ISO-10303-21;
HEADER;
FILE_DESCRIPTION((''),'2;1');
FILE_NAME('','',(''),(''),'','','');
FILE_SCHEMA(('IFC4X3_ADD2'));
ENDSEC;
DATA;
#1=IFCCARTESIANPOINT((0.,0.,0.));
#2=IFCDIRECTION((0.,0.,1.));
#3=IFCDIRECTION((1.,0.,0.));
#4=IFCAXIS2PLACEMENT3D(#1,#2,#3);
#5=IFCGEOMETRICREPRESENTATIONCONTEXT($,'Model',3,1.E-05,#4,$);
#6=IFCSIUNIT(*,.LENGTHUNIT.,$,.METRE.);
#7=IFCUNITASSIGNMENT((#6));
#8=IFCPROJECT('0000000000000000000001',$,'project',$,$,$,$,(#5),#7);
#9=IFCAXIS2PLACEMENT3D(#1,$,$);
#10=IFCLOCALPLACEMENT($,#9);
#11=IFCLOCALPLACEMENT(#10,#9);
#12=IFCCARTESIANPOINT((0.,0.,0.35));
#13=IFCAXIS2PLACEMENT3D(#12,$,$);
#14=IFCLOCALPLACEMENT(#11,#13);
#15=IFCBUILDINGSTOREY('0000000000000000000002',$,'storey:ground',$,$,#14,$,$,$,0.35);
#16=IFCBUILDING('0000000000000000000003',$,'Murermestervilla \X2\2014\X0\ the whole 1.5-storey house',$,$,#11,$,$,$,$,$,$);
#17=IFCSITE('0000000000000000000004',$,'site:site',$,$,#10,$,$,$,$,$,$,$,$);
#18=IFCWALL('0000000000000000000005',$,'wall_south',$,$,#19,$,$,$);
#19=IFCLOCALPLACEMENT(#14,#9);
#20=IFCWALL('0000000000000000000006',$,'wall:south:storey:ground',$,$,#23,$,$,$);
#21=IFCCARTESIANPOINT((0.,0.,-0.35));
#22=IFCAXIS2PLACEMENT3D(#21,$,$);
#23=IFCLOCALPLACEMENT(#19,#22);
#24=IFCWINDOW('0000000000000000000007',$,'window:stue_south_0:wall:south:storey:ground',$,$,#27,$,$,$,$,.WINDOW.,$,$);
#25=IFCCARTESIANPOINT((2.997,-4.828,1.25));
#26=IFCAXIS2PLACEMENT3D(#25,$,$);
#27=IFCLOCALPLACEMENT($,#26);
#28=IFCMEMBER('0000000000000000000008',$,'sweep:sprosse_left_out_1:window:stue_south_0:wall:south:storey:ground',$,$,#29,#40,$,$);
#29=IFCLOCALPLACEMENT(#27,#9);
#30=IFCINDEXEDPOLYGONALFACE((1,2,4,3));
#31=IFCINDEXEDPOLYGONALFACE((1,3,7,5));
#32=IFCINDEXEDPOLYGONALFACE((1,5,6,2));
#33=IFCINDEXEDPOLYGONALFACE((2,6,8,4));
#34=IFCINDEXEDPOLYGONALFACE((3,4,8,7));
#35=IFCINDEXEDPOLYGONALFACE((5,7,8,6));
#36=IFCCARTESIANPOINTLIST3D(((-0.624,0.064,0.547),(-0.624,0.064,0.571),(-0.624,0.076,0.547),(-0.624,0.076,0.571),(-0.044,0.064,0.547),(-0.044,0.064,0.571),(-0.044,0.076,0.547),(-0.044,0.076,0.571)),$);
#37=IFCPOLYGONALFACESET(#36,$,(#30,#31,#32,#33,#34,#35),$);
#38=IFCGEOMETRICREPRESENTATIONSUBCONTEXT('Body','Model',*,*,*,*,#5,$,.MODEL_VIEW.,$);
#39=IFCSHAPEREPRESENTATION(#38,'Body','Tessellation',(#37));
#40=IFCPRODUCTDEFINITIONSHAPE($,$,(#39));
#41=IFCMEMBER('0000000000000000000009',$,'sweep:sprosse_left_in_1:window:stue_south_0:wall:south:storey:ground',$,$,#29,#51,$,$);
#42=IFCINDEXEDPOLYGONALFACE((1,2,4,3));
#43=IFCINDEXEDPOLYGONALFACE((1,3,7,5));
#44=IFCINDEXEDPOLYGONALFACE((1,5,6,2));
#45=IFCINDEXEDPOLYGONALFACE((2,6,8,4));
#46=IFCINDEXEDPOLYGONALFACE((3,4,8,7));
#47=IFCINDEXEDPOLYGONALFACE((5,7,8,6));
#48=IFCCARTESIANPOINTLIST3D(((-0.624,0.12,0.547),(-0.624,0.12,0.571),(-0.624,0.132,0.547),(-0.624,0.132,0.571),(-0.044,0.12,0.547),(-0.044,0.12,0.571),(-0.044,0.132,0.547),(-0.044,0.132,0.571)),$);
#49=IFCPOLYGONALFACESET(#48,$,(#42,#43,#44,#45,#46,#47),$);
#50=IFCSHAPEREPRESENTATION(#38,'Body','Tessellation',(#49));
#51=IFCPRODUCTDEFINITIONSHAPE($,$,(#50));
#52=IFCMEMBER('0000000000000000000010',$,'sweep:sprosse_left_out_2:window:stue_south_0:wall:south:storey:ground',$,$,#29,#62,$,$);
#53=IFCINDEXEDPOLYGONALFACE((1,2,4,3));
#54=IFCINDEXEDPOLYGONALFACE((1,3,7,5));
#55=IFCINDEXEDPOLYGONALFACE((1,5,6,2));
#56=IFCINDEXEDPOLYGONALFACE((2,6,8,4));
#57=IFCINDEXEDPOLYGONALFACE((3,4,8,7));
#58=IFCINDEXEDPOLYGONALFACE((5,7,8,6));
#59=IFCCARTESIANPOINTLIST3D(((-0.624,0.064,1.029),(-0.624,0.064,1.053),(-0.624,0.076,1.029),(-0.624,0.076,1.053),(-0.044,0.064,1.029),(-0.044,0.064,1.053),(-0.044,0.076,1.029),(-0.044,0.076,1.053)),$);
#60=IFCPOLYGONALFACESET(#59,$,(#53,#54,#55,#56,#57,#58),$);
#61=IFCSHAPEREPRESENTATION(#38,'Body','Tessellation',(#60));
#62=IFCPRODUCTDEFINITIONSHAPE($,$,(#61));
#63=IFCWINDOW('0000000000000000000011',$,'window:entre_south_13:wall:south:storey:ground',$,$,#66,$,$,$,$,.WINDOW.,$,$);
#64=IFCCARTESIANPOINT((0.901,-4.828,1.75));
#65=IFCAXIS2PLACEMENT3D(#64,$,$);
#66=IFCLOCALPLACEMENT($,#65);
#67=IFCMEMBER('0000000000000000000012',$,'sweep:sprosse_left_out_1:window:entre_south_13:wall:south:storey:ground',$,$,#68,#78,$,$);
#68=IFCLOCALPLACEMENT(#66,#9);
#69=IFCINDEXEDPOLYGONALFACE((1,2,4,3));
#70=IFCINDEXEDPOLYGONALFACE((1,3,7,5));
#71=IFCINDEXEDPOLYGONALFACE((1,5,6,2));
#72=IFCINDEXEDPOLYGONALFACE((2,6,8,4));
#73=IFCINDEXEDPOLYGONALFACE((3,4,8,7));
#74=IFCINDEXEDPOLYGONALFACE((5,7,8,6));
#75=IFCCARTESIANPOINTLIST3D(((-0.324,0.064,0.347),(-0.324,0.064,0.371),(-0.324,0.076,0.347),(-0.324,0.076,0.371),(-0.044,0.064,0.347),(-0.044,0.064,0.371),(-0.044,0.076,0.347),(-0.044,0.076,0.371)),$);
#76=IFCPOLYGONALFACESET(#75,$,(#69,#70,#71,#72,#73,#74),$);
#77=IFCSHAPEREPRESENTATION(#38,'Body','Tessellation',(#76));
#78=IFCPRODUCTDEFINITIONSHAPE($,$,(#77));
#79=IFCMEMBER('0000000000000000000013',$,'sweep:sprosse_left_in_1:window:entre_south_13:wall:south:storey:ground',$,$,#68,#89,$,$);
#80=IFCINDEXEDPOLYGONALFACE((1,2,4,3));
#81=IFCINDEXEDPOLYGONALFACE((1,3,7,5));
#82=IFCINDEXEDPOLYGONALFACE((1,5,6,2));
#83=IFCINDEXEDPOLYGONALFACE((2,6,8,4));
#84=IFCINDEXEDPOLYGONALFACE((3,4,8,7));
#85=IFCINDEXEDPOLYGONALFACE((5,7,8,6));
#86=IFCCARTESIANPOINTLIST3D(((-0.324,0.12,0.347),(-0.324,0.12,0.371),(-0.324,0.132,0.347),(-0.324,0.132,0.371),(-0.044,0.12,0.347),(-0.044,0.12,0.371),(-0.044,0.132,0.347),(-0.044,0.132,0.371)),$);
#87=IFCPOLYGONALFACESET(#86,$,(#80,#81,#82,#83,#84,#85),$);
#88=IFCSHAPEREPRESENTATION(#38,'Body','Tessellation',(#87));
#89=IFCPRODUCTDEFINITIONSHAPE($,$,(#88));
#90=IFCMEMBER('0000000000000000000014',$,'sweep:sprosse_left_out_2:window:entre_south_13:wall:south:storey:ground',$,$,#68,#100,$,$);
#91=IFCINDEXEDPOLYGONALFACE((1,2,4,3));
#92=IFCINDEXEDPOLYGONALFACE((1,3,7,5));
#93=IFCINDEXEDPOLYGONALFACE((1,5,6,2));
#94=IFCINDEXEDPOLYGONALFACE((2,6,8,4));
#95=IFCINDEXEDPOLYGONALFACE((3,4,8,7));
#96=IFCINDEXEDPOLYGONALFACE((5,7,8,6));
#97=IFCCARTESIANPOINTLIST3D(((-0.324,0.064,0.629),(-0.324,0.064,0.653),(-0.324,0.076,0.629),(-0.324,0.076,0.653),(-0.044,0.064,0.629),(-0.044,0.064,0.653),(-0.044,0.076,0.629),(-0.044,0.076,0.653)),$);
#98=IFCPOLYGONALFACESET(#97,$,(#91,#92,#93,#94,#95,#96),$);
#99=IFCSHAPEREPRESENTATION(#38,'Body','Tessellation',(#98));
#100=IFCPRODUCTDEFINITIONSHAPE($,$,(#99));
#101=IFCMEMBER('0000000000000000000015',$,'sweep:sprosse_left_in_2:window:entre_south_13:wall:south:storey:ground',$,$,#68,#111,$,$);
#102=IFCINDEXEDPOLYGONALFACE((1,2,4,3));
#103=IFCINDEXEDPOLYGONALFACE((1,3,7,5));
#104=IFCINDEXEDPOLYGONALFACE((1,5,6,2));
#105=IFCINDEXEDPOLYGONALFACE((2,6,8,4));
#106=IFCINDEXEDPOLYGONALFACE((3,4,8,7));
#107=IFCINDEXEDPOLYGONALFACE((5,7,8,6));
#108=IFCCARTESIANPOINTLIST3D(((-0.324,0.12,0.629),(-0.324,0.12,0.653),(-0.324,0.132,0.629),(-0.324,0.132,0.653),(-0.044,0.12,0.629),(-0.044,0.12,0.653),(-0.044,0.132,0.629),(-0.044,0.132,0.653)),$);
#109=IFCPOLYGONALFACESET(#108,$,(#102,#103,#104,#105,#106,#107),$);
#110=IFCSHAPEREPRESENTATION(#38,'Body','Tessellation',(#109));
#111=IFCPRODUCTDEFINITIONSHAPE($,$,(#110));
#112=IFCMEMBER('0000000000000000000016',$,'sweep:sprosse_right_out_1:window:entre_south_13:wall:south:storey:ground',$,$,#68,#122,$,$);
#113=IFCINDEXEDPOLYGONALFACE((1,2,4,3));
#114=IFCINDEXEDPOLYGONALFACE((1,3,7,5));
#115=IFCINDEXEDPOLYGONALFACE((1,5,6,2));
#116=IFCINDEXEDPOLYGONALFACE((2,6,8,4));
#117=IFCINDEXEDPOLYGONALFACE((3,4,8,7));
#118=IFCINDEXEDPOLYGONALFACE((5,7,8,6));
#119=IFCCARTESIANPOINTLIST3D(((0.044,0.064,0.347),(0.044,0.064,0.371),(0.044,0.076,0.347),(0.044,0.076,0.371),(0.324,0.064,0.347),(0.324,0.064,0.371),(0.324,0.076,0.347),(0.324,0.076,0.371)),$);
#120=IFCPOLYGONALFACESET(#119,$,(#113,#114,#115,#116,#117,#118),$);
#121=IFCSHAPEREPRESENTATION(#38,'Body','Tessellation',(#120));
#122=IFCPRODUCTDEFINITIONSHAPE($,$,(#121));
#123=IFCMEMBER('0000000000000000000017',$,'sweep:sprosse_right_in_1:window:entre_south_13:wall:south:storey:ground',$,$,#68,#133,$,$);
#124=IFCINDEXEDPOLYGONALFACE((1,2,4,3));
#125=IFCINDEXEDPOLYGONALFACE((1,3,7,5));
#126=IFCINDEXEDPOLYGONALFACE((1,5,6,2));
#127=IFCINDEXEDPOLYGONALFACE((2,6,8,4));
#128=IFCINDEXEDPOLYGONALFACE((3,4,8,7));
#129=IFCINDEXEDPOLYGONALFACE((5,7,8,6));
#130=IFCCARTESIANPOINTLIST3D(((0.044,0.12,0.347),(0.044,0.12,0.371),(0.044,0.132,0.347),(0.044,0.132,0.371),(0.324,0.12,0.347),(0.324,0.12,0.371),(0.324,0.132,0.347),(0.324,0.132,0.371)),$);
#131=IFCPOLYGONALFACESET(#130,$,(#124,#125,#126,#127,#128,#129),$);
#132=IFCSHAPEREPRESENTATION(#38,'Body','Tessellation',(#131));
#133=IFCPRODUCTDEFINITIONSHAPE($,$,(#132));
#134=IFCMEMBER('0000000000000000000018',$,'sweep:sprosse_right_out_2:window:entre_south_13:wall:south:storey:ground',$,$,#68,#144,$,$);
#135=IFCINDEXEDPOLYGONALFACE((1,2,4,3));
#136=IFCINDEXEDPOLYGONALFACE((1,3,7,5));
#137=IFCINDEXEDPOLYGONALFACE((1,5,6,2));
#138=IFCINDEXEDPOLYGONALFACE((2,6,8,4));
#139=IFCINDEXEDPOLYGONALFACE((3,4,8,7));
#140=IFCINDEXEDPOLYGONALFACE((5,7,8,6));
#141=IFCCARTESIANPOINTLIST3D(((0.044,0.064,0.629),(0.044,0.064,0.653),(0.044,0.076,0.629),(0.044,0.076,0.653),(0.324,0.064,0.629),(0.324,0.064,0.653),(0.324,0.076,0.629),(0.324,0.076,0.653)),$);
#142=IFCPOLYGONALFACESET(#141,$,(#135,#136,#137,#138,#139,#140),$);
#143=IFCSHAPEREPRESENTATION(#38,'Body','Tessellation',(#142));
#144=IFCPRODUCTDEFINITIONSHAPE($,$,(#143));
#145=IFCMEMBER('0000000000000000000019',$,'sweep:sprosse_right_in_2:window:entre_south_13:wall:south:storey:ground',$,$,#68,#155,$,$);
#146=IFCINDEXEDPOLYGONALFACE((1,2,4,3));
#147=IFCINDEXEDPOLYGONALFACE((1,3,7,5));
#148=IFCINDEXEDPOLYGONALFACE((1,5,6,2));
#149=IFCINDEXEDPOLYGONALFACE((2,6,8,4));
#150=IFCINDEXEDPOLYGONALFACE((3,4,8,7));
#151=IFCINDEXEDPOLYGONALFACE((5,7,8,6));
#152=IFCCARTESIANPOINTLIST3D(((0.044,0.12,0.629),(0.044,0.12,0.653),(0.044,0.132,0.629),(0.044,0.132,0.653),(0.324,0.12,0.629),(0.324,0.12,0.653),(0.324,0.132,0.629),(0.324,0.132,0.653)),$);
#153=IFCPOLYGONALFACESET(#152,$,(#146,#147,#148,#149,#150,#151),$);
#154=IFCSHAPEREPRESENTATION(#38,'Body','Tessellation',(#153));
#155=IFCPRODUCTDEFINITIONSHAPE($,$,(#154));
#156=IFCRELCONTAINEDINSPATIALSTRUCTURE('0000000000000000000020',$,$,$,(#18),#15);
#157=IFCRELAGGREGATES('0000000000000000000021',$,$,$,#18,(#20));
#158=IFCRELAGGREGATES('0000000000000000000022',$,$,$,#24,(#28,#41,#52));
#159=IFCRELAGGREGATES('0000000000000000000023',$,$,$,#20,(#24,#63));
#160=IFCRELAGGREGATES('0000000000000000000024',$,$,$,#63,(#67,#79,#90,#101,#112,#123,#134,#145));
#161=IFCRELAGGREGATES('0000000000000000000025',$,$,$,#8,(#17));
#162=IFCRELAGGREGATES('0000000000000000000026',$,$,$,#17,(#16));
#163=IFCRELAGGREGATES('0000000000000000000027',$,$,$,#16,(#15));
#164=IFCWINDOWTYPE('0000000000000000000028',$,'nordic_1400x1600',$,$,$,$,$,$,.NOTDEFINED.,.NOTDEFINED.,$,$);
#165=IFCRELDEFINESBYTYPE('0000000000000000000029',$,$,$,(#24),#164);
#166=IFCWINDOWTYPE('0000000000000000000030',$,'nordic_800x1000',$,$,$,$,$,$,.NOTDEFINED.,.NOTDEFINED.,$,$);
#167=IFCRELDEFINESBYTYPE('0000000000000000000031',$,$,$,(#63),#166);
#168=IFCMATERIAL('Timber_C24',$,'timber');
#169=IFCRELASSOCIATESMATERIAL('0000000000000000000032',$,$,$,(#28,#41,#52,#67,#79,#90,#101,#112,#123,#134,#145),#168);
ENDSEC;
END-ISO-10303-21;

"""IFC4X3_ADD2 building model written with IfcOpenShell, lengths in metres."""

from ifc_helpers import new_model, si_unit, frame, origin, origin_with_axes, place, context, subcontext, project, spatial, polyline, outline, extrude, source, transform, mapped, material, type_object, element, aggregate, save


model = new_model("IFC4X3_ADD2")

# Units and contexts
model_context = context("Model", 3, precision=1e-05, world=origin_with_axes())
body_context = subcontext(model_context, "Body", "Model", "MODEL_VIEW")
ifc_project = project(units=[si_unit("LENGTHUNIT", "METRE")], contexts=[model_context])

# Site, building, storey
site_placement = place(None, origin())
site = spatial("IfcSite", under=ifc_project, at=site_placement, Name="site:site")
building_placement = place(site_placement, origin())
building = spatial("IfcBuilding", under=site, at=building_placement, Name="Murermestervilla — the whole 1.5-storey house")
storey_placement = place(building_placement, frame((0.0, 0.0, 0.35)))
storey = spatial("IfcBuildingStorey", under=building, at=storey_placement, Name="storey:ground", Elevation=0.35)

# Walls, windows, members
wall_1_placement = place(storey_placement, origin())
wall_1 = element("IfcWall", 1, at=wall_1_placement, inside=storey, Name="wall_south")
wall_2_placement = place(wall_1_placement, frame((0.0, 0.0, -0.35)))
wall_2 = element("IfcWall", 2, at=wall_2_placement, Name="wall:south:storey:ground")
aggregate(wall_1, [wall_2])
window_type_1 = type_object("IfcWindowType", Name="nordic_1400x1600", PartitioningType="NOTDEFINED", PredefinedType="NOTDEFINED")
window_1_placement = place(None, frame((2.997, -4.828, 1.25)))
window_1 = element("IfcWindow", 3, at=window_1_placement, type_object=window_type_1, Name="window:stue_south_0:wall:south:storey:ground", PredefinedType="WINDOW")
ifc_material_1 = material(Name="Timber_C24", Category="timber")
placement_1 = place(window_1_placement, origin())
shared_shape_1 = source(origin(), body_context, "Body", "SweptSolid", [
    extrude(outline(polyline([(-0.006, -0.012), (0.006, -0.012), (0.006, 0.012), (-0.006, 0.012), (-0.006, -0.012)])), frame((-0.624, 0.07, 0.559), z_axis=(1.0, 0.0, 0.0), x_axis=(0.0, 1.0, 0.0)), (0.0, 0.0, 1.0), 0.58),
])
member_1 = element("IfcMember", 4, at=placement_1, material=ifc_material_1, Name="sweep:sprosse_left_out_1:window:stue_south_0:wall:south:storey:ground", context=body_context, shape_type="MappedRepresentation", body=[
    mapped(shared_shape_1, transform((0.0, 0.0, 0.0))),
])
shared_shape_2 = source(origin(), body_context, "Body", "SweptSolid", [
    extrude(outline(polyline([(-0.006, -0.012), (0.006, -0.012), (0.006, 0.012), (-0.006, 0.012), (-0.006, -0.012)])), frame((-0.624, 0.126, 0.559), z_axis=(1.0, 0.0, 0.0), x_axis=(0.0, 1.0, 0.0)), (0.0, 0.0, 1.0), 0.58),
])
member_2 = element("IfcMember", 5, at=placement_1, material=ifc_material_1, Name="sweep:sprosse_left_in_1:window:stue_south_0:wall:south:storey:ground", context=body_context, shape_type="MappedRepresentation", body=[
    mapped(shared_shape_2, transform((0.0, 0.0, 0.0))),
])
shared_shape_3 = source(origin(), body_context, "Body", "SweptSolid", [
    extrude(outline(polyline([(-0.006, -0.012), (0.006, -0.012), (0.006, 0.012), (-0.006, 0.012), (-0.006, -0.012)])), frame((-0.624, 0.07, 1.041), z_axis=(1.0, 0.0, 0.0), x_axis=(0.0, 1.0, 0.0)), (0.0, 0.0, 1.0), 0.58),
])
member_3 = element("IfcMember", 6, at=placement_1, material=ifc_material_1, Name="sweep:sprosse_left_out_2:window:stue_south_0:wall:south:storey:ground", context=body_context, shape_type="MappedRepresentation", body=[
    mapped(shared_shape_3, transform((0.0, 0.0, 0.0))),
])
aggregate(window_1, [member_1, member_2, member_3])
window_type_2 = type_object("IfcWindowType", Name="nordic_800x1000", PartitioningType="NOTDEFINED", PredefinedType="NOTDEFINED")
window_2_placement = place(None, frame((0.901, -4.828, 1.75)))
window_2 = element("IfcWindow", 7, at=window_2_placement, type_object=window_type_2, Name="window:entre_south_13:wall:south:storey:ground", PredefinedType="WINDOW")
aggregate(wall_2, [window_1, window_2])
placement_2 = place(window_2_placement, origin())
shared_shape_4 = source(origin(), body_context, "Body", "SweptSolid", [
    extrude(outline(polyline([(-0.006, -0.012), (0.006, -0.012), (0.006, 0.012), (-0.006, 0.012), (-0.006, -0.012)])), frame((-0.324, 0.07, 0.359), z_axis=(1.0, 0.0, 0.0), x_axis=(0.0, 1.0, 0.0)), (0.0, 0.0, 1.0), 0.28),
])
member_4 = element("IfcMember", 8, at=placement_2, material=ifc_material_1, Name="sweep:sprosse_left_out_1:window:entre_south_13:wall:south:storey:ground", context=body_context, shape_type="MappedRepresentation", body=[
    mapped(shared_shape_4, transform((0.0, 0.0, 0.0))),
])
shared_shape_5 = source(origin(), body_context, "Body", "SweptSolid", [
    extrude(outline(polyline([(-0.006, -0.012), (0.006, -0.012), (0.006, 0.012), (-0.006, 0.012), (-0.006, -0.012)])), frame((-0.324, 0.126, 0.359), z_axis=(1.0, 0.0, 0.0), x_axis=(0.0, 1.0, 0.0)), (0.0, 0.0, 1.0), 0.28),
])
member_5 = element("IfcMember", 9, at=placement_2, material=ifc_material_1, Name="sweep:sprosse_left_in_1:window:entre_south_13:wall:south:storey:ground", context=body_context, shape_type="MappedRepresentation", body=[
    mapped(shared_shape_5, transform((0.0, 0.0, 0.0))),
])
shared_shape_6 = source(origin(), body_context, "Body", "SweptSolid", [
    extrude(outline(polyline([(-0.006, -0.012), (0.006, -0.012), (0.006, 0.012), (-0.006, 0.012), (-0.006, -0.012)])), frame((-0.324, 0.07, 0.641), z_axis=(1.0, 0.0, 0.0), x_axis=(0.0, 1.0, 0.0)), (0.0, 0.0, 1.0), 0.28),
])
member_6 = element("IfcMember", 10, at=placement_2, material=ifc_material_1, Name="sweep:sprosse_left_out_2:window:entre_south_13:wall:south:storey:ground", context=body_context, shape_type="MappedRepresentation", body=[
    mapped(shared_shape_6, transform((0.0, 0.0, 0.0))),
])
shared_shape_7 = source(origin(), body_context, "Body", "SweptSolid", [
    extrude(outline(polyline([(-0.006, -0.012), (0.006, -0.012), (0.006, 0.012), (-0.006, 0.012), (-0.006, -0.012)])), frame((-0.324, 0.126, 0.641), z_axis=(1.0, 0.0, 0.0), x_axis=(0.0, 1.0, 0.0)), (0.0, 0.0, 1.0), 0.28),
])
member_7 = element("IfcMember", 11, at=placement_2, material=ifc_material_1, Name="sweep:sprosse_left_in_2:window:entre_south_13:wall:south:storey:ground", context=body_context, shape_type="MappedRepresentation", body=[
    mapped(shared_shape_7, transform((0.0, 0.0, 0.0))),
])
shared_shape_8 = source(origin(), body_context, "Body", "SweptSolid", [
    extrude(outline(polyline([(-0.006, -0.012), (0.006, -0.012), (0.006, 0.012), (-0.006, 0.012), (-0.006, -0.012)])), frame((0.044, 0.07, 0.359), z_axis=(1.0, 0.0, 0.0), x_axis=(0.0, 1.0, 0.0)), (0.0, 0.0, 1.0), 0.28),
])
member_8 = element("IfcMember", 12, at=placement_2, material=ifc_material_1, Name="sweep:sprosse_right_out_1:window:entre_south_13:wall:south:storey:ground", context=body_context, shape_type="MappedRepresentation", body=[
    mapped(shared_shape_8, transform((0.0, 0.0, 0.0))),
])
shared_shape_9 = source(origin(), body_context, "Body", "SweptSolid", [
    extrude(outline(polyline([(-0.006, -0.012), (0.006, -0.012), (0.006, 0.012), (-0.006, 0.012), (-0.006, -0.012)])), frame((0.044, 0.126, 0.359), z_axis=(1.0, 0.0, 0.0), x_axis=(0.0, 1.0, 0.0)), (0.0, 0.0, 1.0), 0.28),
])
member_9 = element("IfcMember", 13, at=placement_2, material=ifc_material_1, Name="sweep:sprosse_right_in_1:window:entre_south_13:wall:south:storey:ground", context=body_context, shape_type="MappedRepresentation", body=[
    mapped(shared_shape_9, transform((0.0, 0.0, 0.0))),
])
shared_shape_10 = source(origin(), body_context, "Body", "SweptSolid", [
    extrude(outline(polyline([(-0.006, -0.012), (0.006, -0.012), (0.006, 0.012), (-0.006, 0.012), (-0.006, -0.012)])), frame((0.044, 0.07, 0.641), z_axis=(1.0, 0.0, 0.0), x_axis=(0.0, 1.0, 0.0)), (0.0, 0.0, 1.0), 0.28),
])
member_10 = element("IfcMember", 14, at=placement_2, material=ifc_material_1, Name="sweep:sprosse_right_out_2:window:entre_south_13:wall:south:storey:ground", context=body_context, shape_type="MappedRepresentation", body=[
    mapped(shared_shape_10, transform((0.0, 0.0, 0.0))),
])
shared_shape_11 = source(origin(), body_context, "Body", "SweptSolid", [
    extrude(outline(polyline([(-0.006, -0.012), (0.006, -0.012), (0.006, 0.012), (-0.006, 0.012), (-0.006, -0.012)])), frame((0.044, 0.126, 0.641), z_axis=(1.0, 0.0, 0.0), x_axis=(0.0, 1.0, 0.0)), (0.0, 0.0, 1.0), 0.28),
])
member_11 = element("IfcMember", 15, at=placement_2, material=ifc_material_1, Name="sweep:sprosse_right_in_2:window:entre_south_13:wall:south:storey:ground", context=body_context, shape_type="MappedRepresentation", body=[
    mapped(shared_shape_11, transform((0.0, 0.0, 0.0))),
])
aggregate(window_2, [member_4, member_5, member_6, member_7, member_8, member_9, member_10, member_11])

save(model, "model.ifc")
